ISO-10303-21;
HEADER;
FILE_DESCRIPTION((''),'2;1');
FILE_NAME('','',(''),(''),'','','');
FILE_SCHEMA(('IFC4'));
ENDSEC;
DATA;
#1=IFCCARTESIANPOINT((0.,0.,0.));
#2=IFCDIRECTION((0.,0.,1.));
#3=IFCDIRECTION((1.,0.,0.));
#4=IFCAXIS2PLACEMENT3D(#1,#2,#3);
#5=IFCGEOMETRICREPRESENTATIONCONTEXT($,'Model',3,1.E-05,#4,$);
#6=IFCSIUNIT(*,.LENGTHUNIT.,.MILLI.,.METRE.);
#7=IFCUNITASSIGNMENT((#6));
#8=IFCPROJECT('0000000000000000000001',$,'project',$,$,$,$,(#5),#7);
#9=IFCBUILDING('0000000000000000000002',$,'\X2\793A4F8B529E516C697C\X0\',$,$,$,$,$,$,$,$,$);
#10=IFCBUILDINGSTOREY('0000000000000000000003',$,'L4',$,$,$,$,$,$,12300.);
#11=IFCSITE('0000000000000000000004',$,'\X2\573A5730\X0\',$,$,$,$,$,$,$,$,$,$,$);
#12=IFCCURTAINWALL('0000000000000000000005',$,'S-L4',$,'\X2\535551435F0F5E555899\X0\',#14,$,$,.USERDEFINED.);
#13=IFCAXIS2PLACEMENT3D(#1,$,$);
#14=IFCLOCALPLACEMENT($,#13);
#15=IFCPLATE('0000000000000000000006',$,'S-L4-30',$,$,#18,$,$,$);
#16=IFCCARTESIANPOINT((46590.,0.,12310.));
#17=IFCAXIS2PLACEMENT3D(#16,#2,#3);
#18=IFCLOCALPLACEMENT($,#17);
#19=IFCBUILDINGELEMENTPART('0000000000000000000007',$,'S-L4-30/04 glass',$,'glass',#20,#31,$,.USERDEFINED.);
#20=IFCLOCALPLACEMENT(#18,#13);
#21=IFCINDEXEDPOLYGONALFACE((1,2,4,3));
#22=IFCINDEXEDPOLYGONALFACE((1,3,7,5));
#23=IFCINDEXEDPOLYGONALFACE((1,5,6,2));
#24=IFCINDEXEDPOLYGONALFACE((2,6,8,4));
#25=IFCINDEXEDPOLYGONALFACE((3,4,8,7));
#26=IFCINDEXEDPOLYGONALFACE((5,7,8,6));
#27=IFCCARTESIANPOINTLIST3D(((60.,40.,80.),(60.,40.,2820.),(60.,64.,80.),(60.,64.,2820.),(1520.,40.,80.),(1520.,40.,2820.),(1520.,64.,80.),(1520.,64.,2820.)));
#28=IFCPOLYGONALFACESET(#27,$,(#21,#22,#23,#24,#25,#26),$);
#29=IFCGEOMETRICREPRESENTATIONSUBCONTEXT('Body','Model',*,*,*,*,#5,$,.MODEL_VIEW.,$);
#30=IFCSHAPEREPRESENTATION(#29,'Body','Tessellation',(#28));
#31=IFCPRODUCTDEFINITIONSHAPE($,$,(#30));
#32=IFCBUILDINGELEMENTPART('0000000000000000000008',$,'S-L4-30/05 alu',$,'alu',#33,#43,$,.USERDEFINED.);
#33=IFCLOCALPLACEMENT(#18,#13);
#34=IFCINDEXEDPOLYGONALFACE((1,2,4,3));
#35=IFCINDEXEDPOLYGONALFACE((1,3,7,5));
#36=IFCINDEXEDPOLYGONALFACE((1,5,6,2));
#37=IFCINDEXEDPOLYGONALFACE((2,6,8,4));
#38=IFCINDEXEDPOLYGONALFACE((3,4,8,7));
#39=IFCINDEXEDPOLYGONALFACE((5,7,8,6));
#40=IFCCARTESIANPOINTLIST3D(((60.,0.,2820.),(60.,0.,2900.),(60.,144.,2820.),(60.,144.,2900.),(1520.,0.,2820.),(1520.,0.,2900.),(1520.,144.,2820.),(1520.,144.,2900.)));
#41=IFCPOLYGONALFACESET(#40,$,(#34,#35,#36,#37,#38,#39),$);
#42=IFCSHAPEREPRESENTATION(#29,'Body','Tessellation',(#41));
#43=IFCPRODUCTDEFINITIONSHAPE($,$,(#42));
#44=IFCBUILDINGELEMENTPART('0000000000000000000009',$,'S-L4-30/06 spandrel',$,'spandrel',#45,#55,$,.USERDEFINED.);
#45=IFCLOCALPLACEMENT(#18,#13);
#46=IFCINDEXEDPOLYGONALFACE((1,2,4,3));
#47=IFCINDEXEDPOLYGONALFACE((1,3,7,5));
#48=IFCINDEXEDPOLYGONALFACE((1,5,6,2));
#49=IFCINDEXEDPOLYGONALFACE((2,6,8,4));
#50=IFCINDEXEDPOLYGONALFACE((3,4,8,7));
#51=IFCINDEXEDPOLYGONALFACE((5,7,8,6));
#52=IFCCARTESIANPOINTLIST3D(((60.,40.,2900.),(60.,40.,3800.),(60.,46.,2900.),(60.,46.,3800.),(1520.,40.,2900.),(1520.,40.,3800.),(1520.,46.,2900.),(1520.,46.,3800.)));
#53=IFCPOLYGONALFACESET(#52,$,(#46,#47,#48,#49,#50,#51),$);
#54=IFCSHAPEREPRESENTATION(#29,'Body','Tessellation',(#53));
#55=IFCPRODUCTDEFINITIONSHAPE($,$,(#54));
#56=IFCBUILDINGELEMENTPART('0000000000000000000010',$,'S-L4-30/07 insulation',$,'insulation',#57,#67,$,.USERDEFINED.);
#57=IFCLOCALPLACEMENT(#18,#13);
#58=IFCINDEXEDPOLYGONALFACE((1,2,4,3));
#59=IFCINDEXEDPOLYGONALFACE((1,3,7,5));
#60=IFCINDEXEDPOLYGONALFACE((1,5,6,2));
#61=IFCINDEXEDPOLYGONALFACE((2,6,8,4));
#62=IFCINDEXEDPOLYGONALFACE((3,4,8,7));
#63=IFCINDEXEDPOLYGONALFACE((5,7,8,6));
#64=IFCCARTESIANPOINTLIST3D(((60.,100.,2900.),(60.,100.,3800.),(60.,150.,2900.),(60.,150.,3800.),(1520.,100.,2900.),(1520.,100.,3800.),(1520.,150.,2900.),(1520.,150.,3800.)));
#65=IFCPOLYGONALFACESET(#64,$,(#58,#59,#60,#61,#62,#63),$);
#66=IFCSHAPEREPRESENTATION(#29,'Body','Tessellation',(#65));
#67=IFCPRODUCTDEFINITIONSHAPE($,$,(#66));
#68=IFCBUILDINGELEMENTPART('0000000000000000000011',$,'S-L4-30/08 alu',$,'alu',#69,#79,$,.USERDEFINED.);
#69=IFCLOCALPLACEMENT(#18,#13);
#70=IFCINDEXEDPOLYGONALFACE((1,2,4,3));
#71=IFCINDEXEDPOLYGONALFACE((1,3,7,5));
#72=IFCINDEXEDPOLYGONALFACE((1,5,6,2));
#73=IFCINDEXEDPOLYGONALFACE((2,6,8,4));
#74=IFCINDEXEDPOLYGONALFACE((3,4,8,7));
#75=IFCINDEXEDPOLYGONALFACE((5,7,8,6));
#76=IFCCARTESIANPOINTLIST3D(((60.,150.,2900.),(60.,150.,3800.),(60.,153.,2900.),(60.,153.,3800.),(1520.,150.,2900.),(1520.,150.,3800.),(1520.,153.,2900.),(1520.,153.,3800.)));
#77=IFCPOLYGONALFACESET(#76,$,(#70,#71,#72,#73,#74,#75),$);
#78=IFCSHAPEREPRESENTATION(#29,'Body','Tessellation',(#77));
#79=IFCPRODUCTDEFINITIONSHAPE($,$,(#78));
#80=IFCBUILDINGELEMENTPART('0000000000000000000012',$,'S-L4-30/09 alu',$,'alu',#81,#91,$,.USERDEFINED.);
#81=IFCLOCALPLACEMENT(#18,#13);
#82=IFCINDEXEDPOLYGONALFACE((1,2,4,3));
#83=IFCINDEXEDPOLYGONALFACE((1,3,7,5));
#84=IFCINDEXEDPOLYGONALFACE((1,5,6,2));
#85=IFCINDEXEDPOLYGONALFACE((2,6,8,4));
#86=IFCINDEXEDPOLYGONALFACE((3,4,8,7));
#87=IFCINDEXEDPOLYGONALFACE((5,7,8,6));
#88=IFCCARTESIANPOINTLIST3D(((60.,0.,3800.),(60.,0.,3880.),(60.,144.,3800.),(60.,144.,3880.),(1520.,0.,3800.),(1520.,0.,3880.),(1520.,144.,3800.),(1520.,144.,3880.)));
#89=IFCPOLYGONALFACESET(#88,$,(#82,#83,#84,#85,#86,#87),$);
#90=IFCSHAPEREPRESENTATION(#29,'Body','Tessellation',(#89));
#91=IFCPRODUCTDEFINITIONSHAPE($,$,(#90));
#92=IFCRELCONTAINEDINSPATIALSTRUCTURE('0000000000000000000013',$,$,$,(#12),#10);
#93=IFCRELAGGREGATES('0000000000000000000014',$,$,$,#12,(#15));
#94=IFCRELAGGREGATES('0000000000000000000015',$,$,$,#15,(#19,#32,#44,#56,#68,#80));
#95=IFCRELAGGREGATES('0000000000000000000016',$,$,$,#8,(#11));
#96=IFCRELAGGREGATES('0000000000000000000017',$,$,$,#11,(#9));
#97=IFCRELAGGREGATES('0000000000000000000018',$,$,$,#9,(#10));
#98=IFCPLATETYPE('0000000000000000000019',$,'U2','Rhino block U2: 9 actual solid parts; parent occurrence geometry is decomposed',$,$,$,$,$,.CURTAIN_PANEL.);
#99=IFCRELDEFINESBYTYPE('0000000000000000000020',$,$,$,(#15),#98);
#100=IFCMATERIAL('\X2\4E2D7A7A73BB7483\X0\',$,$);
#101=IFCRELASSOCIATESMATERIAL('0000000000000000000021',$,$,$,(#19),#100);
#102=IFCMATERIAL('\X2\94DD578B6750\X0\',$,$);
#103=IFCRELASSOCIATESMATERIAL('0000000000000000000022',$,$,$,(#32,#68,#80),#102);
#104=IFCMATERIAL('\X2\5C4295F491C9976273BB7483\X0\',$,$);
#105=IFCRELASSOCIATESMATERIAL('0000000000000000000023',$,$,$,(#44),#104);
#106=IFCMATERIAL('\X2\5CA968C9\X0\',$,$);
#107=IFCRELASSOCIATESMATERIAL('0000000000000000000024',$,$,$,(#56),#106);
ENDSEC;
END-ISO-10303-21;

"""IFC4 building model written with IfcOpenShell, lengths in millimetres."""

from ifc_helpers import new_model, si_unit, frame, frame_2d, origin, origin_with_axes, place, context, subcontext, project, spatial, rectangle, extrude, source, transform, mapped, material, type_object, element, aggregate, save


model = new_model("IFC4")

# Units and contexts
model_context = context("Model", 3, precision=1e-05, world=origin_with_axes())
body_context = subcontext(model_context, "Body", "Model", "MODEL_VIEW")
ifc_project = project(units=[si_unit("LENGTHUNIT", "METRE", prefix="MILLI")], contexts=[model_context])

# Site, building, storey
site = spatial("IfcSite", under=ifc_project, Name="场地")
building = spatial("IfcBuilding", under=site, Name="示例办公楼")
storey = spatial("IfcBuildingStorey", under=building, Name="L4", Elevation=12300.0)

# Curtain wall, plate
curtain_wall_1 = element("IfcCurtainWall", 1, inside=storey, Name="S-L4", ObjectType="单元式幕墙", PredefinedType="USERDEFINED")
plate_type = type_object("IfcPlateType", Name="U2", Description="Rhino block U2: 9 actual solid parts; parent occurrence geometry is decomposed", PredefinedType="CURTAIN_PANEL")
plate_1_placement = place(None, frame((46590.0, 0.0, 12310.0), z_axis=(0.0, 0.0, 1.0), x_axis=(1.0, 0.0, 0.0)))
plate_1 = element("IfcPlate", 2, at=plate_1_placement, type_object=plate_type, Name="S-L4-30")
aggregate(curtain_wall_1, [plate_1])
ifc_material_1 = material(Name="铝型材")

# Building element parts
ifc_material_2 = material(Name="中空玻璃")
shared_shape_1 = source(origin(), body_context, "Body", "SweptSolid", [
    extrude(rectangle(XDim=1460.0, YDim=24.0, at=frame_2d((790.0, 52.0))), frame((0.0, 0.0, 80.0)), (0.0, 0.0, 1.0), 2740.0),
])
building_element_part_1_placement = place(plate_1_placement, origin())
building_element_part_1 = element("IfcBuildingElementPart", 3, at=building_element_part_1_placement, material=ifc_material_2, Name="S-L4-30/04 glass", ObjectType="glass", PredefinedType="USERDEFINED", context=body_context, shape_type="MappedRepresentation", body=[
    mapped(shared_shape_1, transform((0.0, 0.0, 0.0))),
])
shared_shape_2 = source(origin(), body_context, "Body", "SweptSolid", [
    extrude(rectangle(XDim=1460.0, YDim=144.0, at=frame_2d((790.0, 72.0))), frame((0.0, 0.0, 2820.0)), (0.0, 0.0, 1.0), 80.0),
])
building_element_part_2_placement = place(plate_1_placement, origin())
building_element_part_2 = element("IfcBuildingElementPart", 4, at=building_element_part_2_placement, material=ifc_material_1, Name="S-L4-30/05 alu", ObjectType="alu", PredefinedType="USERDEFINED", context=body_context, shape_type="MappedRepresentation", body=[
    mapped(shared_shape_2, transform((0.0, 0.0, 0.0))),
])
ifc_material_3 = material(Name="层间釉面玻璃")
shared_shape_3 = source(origin(), body_context, "Body", "SweptSolid", [
    extrude(rectangle(XDim=1460.0, YDim=6.0, at=frame_2d((790.0, 43.0))), frame((0.0, 0.0, 2900.0)), (0.0, 0.0, 1.0), 900.0),
])
building_element_part_3_placement = place(plate_1_placement, origin())
building_element_part_3 = element("IfcBuildingElementPart", 5, at=building_element_part_3_placement, material=ifc_material_3, Name="S-L4-30/06 spandrel", ObjectType="spandrel", PredefinedType="USERDEFINED", context=body_context, shape_type="MappedRepresentation", body=[
    mapped(shared_shape_3, transform((0.0, 0.0, 0.0))),
])
ifc_material_4 = material(Name="岩棉")
shared_shape_4 = source(origin(), body_context, "Body", "SweptSolid", [
    extrude(rectangle(XDim=1460.0, YDim=50.0, at=frame_2d((790.0, 125.0))), frame((0.0, 0.0, 2900.0)), (0.0, 0.0, 1.0), 900.0),
])
building_element_part_4_placement = place(plate_1_placement, origin())
building_element_part_4 = element("IfcBuildingElementPart", 6, at=building_element_part_4_placement, material=ifc_material_4, Name="S-L4-30/07 insulation", ObjectType="insulation", PredefinedType="USERDEFINED", context=body_context, shape_type="MappedRepresentation", body=[
    mapped(shared_shape_4, transform((0.0, 0.0, 0.0))),
])
shared_shape_5 = source(origin(), body_context, "Body", "SweptSolid", [
    extrude(rectangle(XDim=1460.0, YDim=3.0, at=frame_2d((790.0, 151.5))), frame((0.0, 0.0, 2900.0)), (0.0, 0.0, 1.0), 900.0),
])
building_element_part_5_placement = place(plate_1_placement, origin())
building_element_part_5 = element("IfcBuildingElementPart", 7, at=building_element_part_5_placement, material=ifc_material_1, Name="S-L4-30/08 alu", ObjectType="alu", PredefinedType="USERDEFINED", context=body_context, shape_type="MappedRepresentation", body=[
    mapped(shared_shape_5, transform((0.0, 0.0, 0.0))),
])
shared_shape_6 = source(origin(), body_context, "Body", "SweptSolid", [
    extrude(rectangle(XDim=1460.0, YDim=144.0, at=frame_2d((790.0, 72.0))), frame((0.0, 0.0, 3800.0)), (0.0, 0.0, 1.0), 80.0),
])
building_element_part_6_placement = place(plate_1_placement, origin())
building_element_part_6 = element("IfcBuildingElementPart", 8, at=building_element_part_6_placement, material=ifc_material_1, Name="S-L4-30/09 alu", ObjectType="alu", PredefinedType="USERDEFINED", context=body_context, shape_type="MappedRepresentation", body=[
    mapped(shared_shape_6, transform((0.0, 0.0, 0.0))),
])
aggregate(plate_1, [building_element_part_1, building_element_part_2, building_element_part_3, building_element_part_4, building_element_part_5, building_element_part_6])

save(model, "model.ifc")
